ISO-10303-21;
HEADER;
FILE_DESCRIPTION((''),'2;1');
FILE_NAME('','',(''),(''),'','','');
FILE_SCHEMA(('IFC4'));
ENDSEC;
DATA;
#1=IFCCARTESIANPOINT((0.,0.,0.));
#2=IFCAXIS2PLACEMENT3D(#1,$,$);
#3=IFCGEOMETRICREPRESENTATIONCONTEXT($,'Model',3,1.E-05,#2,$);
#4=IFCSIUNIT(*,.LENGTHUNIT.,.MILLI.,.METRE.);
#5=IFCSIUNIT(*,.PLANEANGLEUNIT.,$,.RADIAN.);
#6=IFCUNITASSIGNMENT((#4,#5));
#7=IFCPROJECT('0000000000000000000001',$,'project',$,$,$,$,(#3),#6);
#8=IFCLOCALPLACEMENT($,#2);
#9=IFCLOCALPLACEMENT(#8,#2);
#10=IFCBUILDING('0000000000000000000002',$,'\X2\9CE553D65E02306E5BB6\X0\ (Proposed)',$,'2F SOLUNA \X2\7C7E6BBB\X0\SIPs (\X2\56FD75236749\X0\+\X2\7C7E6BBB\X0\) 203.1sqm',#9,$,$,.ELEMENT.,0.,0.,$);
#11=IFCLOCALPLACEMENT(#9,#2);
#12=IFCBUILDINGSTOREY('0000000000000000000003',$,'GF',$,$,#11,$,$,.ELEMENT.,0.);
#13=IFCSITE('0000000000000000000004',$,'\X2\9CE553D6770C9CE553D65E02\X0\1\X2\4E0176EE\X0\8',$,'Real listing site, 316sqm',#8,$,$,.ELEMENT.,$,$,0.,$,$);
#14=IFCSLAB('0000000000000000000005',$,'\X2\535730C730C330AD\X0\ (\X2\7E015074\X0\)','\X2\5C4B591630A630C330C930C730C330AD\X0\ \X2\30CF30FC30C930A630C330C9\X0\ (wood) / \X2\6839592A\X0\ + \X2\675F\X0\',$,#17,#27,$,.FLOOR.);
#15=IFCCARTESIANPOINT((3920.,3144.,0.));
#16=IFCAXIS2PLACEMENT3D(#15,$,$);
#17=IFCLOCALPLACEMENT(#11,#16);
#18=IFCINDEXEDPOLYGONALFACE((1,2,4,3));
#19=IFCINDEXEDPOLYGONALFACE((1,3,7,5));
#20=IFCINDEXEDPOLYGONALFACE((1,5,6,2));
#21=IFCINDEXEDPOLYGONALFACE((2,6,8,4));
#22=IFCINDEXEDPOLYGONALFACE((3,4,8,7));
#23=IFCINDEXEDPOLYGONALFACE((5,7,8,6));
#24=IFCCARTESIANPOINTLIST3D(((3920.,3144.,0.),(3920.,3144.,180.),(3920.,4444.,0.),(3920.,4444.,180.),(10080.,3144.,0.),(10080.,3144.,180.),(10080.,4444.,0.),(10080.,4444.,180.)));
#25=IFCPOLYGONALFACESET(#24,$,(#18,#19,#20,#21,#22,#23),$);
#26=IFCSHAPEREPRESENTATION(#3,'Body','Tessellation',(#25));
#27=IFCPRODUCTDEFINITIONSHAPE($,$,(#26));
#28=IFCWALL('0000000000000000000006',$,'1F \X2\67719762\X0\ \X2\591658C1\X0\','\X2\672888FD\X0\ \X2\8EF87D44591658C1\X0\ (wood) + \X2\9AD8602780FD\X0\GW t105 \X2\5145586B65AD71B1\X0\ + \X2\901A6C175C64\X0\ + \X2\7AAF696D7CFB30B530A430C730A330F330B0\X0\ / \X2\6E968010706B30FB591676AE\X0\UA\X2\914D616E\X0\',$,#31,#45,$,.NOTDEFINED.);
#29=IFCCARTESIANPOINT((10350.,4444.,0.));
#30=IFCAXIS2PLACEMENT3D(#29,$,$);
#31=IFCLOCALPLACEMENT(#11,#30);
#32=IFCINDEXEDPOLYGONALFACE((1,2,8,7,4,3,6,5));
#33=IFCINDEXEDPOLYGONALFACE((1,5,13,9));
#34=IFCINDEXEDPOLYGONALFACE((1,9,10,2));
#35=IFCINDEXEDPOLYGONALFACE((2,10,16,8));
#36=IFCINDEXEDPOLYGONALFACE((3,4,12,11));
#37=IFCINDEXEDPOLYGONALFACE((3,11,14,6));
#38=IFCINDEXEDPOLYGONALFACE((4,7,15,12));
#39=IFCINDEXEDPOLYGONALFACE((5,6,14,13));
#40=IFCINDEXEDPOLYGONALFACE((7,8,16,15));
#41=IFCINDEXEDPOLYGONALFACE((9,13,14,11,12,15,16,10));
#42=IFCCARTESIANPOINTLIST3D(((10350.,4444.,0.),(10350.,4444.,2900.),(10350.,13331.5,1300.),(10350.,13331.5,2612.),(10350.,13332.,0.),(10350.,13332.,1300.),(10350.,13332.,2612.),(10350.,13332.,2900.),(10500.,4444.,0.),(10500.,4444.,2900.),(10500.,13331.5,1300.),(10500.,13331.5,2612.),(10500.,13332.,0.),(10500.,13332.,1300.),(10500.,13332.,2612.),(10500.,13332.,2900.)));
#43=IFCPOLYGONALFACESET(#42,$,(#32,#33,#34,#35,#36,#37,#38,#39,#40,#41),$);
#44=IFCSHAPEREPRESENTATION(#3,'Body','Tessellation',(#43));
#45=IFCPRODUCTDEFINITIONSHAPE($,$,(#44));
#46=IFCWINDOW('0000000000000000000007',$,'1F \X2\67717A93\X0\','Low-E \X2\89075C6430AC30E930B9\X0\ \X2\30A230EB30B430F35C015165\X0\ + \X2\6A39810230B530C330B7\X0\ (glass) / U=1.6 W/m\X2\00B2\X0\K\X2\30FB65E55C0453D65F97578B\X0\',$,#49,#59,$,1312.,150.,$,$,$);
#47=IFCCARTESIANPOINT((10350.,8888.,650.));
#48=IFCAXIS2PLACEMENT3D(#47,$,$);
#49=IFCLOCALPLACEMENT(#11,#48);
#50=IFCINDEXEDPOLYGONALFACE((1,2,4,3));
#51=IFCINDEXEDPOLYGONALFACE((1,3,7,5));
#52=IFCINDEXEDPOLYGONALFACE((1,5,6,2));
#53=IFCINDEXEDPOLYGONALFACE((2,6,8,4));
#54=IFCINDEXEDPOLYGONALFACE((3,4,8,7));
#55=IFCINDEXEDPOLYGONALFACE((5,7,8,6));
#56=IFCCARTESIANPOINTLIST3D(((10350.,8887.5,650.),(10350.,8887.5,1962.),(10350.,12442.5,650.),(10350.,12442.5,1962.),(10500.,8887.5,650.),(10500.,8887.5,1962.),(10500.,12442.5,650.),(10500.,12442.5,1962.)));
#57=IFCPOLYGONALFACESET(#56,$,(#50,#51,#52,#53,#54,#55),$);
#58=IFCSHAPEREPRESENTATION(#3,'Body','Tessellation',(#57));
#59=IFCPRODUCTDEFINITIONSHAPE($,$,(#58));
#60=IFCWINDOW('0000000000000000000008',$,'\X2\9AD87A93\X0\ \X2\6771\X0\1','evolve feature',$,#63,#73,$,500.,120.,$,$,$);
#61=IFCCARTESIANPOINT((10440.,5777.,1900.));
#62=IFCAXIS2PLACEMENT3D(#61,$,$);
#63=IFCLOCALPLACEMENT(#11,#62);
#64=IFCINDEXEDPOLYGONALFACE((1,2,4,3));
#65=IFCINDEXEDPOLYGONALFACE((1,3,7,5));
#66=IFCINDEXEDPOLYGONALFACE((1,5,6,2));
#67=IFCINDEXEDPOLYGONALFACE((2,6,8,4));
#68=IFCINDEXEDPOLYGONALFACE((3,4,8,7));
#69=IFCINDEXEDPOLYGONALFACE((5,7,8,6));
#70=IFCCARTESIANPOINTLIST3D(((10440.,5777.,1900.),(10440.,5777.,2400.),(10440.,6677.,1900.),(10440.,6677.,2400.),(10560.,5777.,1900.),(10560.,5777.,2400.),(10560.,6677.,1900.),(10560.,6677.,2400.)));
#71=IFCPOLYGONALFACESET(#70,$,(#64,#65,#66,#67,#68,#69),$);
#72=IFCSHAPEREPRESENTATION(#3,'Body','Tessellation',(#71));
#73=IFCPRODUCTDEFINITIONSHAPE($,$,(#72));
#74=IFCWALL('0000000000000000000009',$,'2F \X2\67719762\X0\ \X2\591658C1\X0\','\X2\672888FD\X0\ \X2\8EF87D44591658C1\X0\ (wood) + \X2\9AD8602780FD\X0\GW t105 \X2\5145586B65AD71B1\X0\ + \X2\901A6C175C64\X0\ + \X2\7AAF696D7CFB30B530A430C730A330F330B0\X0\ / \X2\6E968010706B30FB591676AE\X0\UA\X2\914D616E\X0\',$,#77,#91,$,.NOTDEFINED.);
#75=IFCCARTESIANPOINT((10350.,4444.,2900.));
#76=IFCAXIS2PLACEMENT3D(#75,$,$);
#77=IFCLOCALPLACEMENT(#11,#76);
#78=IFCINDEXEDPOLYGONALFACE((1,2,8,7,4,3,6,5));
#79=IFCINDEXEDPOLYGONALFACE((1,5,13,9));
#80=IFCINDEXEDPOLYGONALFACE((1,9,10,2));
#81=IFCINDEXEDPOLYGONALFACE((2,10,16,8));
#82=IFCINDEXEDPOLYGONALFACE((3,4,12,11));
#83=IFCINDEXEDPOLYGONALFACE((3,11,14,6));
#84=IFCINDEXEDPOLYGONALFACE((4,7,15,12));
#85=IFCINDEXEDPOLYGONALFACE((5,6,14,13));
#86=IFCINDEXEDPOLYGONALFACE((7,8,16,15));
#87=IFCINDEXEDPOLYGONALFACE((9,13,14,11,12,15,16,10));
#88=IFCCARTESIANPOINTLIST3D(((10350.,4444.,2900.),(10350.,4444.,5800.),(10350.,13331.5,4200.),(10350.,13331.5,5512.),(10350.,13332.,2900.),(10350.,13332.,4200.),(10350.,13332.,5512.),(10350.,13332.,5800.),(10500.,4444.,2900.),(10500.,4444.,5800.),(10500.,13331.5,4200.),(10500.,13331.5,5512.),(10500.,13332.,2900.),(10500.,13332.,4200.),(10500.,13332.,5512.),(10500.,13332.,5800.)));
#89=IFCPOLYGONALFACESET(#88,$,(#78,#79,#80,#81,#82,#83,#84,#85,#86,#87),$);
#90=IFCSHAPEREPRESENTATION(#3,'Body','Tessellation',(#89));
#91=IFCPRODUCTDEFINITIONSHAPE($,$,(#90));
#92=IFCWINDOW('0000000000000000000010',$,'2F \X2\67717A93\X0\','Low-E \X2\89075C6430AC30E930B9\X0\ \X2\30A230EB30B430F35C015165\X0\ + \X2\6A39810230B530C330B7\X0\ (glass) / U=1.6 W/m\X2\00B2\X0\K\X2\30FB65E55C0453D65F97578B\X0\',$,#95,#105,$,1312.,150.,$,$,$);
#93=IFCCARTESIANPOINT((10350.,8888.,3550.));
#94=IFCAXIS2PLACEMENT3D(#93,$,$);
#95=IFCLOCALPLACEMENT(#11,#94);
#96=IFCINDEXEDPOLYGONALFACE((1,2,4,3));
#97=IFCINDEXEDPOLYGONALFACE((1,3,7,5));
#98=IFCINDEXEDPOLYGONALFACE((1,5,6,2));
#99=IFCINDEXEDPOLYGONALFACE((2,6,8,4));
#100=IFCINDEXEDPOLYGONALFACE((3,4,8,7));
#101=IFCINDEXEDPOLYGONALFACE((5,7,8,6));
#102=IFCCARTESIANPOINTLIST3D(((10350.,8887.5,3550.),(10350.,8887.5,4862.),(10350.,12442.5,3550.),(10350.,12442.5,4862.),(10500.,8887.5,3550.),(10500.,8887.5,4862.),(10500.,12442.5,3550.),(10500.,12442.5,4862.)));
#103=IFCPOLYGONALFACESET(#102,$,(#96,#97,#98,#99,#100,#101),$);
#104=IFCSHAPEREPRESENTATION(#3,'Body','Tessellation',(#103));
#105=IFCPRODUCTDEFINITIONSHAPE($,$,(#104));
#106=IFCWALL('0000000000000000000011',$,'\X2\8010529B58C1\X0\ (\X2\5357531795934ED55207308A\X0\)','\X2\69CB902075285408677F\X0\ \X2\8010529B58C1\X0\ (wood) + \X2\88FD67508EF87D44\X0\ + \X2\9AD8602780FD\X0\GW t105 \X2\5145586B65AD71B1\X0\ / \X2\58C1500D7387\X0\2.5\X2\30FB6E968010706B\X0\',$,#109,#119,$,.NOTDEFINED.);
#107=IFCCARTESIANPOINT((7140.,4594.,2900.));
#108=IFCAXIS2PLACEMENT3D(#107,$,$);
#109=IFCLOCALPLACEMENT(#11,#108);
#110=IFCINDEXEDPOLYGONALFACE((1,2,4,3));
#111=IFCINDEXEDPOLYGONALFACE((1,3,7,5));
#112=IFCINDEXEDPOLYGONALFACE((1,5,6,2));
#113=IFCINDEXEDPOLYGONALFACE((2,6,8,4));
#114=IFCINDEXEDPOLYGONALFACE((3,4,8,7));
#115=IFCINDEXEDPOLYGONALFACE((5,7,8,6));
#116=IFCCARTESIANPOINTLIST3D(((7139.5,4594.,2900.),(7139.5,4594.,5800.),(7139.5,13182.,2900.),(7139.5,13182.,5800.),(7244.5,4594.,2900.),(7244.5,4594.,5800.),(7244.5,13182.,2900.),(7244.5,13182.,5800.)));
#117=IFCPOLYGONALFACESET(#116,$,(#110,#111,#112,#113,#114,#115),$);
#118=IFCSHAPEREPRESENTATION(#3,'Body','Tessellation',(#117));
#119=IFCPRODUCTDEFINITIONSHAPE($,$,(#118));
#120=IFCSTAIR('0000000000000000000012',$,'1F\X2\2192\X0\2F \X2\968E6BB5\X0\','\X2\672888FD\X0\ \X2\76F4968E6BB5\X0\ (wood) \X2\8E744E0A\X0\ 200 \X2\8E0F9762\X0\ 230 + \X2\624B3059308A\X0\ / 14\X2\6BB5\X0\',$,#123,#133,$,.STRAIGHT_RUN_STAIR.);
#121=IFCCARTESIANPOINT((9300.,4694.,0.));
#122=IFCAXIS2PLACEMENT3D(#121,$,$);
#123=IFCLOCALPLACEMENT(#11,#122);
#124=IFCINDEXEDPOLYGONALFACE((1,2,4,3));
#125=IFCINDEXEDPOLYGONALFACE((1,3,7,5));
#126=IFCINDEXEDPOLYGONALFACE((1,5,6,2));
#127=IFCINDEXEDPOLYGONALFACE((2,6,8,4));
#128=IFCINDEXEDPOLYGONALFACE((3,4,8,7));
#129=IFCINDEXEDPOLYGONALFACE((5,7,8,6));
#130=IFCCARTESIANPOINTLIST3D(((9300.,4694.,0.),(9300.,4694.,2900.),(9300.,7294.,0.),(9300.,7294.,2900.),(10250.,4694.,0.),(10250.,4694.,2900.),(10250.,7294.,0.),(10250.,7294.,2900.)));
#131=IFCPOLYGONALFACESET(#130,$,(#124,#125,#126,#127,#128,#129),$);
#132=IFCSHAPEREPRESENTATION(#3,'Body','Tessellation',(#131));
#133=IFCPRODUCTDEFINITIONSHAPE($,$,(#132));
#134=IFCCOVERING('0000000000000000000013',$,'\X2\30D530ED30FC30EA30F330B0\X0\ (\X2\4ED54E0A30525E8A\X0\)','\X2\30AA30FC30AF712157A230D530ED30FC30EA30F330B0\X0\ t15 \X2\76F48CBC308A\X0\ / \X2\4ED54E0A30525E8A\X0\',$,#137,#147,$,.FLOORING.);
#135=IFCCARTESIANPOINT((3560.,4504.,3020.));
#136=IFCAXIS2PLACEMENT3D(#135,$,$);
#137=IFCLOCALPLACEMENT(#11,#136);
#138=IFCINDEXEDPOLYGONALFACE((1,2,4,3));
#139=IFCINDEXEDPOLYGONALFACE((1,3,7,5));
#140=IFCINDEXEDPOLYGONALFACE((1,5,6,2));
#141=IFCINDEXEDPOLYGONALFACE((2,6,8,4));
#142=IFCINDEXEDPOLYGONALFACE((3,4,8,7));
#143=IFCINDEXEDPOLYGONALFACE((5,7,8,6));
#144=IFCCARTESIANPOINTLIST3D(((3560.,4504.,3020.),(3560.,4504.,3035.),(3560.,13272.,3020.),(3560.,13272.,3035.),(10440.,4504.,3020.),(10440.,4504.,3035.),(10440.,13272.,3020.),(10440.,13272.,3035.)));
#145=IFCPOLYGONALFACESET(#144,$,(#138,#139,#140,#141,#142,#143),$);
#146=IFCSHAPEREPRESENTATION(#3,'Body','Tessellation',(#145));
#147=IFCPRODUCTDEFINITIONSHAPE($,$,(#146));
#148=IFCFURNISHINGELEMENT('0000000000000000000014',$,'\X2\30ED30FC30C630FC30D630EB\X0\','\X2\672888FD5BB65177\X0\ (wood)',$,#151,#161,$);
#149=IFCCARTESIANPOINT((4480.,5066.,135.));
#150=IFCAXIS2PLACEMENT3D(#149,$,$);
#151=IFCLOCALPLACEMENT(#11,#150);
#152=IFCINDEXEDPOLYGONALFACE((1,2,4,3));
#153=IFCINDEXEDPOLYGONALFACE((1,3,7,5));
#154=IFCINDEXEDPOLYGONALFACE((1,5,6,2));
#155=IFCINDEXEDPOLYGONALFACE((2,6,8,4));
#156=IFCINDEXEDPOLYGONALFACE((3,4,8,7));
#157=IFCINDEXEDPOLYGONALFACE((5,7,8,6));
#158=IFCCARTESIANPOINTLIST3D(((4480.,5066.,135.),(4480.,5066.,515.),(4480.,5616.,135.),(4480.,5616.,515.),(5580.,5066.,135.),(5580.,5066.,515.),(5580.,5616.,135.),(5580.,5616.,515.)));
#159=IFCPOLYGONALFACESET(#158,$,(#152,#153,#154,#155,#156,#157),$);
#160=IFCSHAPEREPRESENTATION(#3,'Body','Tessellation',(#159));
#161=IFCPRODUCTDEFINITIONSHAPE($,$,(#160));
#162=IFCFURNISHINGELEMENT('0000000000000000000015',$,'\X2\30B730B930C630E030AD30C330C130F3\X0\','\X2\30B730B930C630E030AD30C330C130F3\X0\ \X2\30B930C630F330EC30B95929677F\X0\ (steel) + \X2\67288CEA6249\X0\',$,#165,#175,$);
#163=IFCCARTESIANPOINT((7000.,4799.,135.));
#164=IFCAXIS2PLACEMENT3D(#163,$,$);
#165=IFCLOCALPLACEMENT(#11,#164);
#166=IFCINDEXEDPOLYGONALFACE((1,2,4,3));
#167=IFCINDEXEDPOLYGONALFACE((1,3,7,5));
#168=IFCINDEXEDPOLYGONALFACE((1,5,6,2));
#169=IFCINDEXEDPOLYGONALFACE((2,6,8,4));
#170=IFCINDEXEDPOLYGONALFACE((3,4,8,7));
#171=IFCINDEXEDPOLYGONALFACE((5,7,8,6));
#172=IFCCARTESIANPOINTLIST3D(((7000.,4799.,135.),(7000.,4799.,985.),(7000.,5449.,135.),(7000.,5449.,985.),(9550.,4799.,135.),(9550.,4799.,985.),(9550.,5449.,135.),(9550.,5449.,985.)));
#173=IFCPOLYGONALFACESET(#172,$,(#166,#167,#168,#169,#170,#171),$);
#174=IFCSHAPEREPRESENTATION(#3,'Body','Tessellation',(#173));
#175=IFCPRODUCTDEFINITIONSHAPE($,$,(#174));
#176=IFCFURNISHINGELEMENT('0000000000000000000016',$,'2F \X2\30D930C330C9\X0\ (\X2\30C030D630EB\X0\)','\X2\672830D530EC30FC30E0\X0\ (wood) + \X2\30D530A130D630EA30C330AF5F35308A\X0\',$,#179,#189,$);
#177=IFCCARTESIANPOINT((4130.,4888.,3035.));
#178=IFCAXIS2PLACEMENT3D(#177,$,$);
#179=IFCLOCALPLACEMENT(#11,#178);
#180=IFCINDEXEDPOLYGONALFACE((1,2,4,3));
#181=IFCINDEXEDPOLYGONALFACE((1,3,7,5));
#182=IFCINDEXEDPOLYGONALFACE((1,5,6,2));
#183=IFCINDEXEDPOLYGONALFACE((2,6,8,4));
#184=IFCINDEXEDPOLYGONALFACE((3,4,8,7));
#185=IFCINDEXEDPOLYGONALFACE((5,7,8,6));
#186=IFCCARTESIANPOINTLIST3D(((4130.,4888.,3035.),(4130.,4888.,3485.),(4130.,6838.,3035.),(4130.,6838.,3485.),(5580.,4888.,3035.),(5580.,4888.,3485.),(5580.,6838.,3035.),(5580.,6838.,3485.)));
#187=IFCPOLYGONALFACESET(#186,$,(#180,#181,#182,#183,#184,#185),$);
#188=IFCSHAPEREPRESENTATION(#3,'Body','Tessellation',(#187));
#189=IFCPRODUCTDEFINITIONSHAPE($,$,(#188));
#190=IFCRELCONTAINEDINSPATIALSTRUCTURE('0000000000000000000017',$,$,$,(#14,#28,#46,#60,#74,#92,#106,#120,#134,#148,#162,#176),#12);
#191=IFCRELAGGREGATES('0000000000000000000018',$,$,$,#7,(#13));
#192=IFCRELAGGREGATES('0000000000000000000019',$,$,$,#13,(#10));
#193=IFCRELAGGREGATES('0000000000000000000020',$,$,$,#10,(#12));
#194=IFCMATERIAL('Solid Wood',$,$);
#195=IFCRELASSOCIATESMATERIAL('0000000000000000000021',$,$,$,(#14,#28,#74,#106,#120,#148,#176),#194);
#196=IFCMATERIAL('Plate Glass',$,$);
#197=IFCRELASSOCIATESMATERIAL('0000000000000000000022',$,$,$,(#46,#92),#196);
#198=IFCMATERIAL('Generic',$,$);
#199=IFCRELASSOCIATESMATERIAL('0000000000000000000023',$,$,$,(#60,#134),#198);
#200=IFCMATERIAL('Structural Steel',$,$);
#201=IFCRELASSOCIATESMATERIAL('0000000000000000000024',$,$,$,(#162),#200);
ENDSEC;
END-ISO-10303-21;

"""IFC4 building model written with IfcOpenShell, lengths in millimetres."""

from ifc_helpers import new_model, si_unit, frame, frame_2d, origin, place, context, project, spatial, rectangle, extrude, material, element, fill, save


model = new_model("IFC4")

# Units and contexts
model_context = context("Model", 3, precision=1e-05, world=origin())
ifc_project = project(units=[si_unit("LENGTHUNIT", "METRE", prefix="MILLI"), si_unit("PLANEANGLEUNIT", "RADIAN")], contexts=[model_context])

# Site, building, storey
site_placement = place(None, origin())
site = spatial("IfcSite", under=ifc_project, at=site_placement, Name="鳥取県鳥取市1丁目8", ObjectType="Real listing site, 316sqm", CompositionType="ELEMENT", RefElevation=0.0)
building_placement = place(site_placement, origin())
building = spatial("IfcBuilding", under=site, at=building_placement, Name="鳥取市の家 (Proposed)", ObjectType="2F SOLUNA 籾殻SIPs (国産杉+籾殻) 203.1sqm", CompositionType="ELEMENT", ElevationOfRefHeight=0.0, ElevationOfTerrain=0.0)
storey_placement = place(building_placement, origin())
storey = spatial("IfcBuildingStorey", under=building, at=storey_placement, Name="GF", CompositionType="ELEMENT", Elevation=0.0)

# Slab
ifc_material_1 = material(Name="Solid Wood")
slab_placement = place(storey_placement, frame((3920.0, 3144.0, 0.0)))
element("IfcSlab", 1, at=slab_placement, inside=storey, material=ifc_material_1, Name="南デッキ (縁側)", Description="屋外ウッドデッキ ハードウッド (wood) / 根太 + 束", PredefinedType="FLOOR", context=model_context, shape_type="SweptSolid", body=[
    extrude(rectangle(XDim=6160.0, YDim=1300.0, at=frame_2d((3080.0, 650.0))), frame((3920.0, 3144.0, 0.0)), (0.0, 0.0, 1.0), 180.0),
])

# Wall, openings, windows
wall_1_placement = place(storey_placement, frame((10350.0, 4444.0, 0.0)))
wall_1 = element("IfcWall", 2, at=wall_1_placement, inside=storey, material=ifc_material_1, Name="1F 東面 外壁", Description="木製 軸組外壁 (wood) + 高性能GW t105 充填断熱 + 通気層 + 窯業系サイディング / 準耐火・外皮UA配慮", PredefinedType="NOTDEFINED", context=model_context, shape_type="SweptSolid", body=[
    extrude(rectangle(XDim=150.0, YDim=8888.0, at=frame_2d((75.0, 4444.0))), frame((10350.0, 4444.0, 0.0)), (0.0, 0.0, 1.0), 2900.0),
])
opening_1_placement = place(storey_placement, frame((10350.0, 8888.0, 650.0)))
opening_1 = element("IfcOpeningElement", 3, at=opening_1_placement, cuts=wall_1, PredefinedType="NOTDEFINED", context=model_context, shape_type="SweptSolid", body=[
    extrude(rectangle(XDim=150.0, YDim=3555.0, at=frame_2d((75.0, 1777.0))), frame((10350.0, 8888.0, 650.0)), (0.0, 0.0, 1.0), 1312.0),
])
opening_2_placement = place(storey_placement, frame((10440.0, 5777.0, 1900.0)))
opening_2 = element("IfcOpeningElement", 4, at=opening_2_placement, cuts=wall_1, PredefinedType="NOTDEFINED", context=model_context, shape_type="SweptSolid", body=[
    extrude(rectangle(XDim=120.0, YDim=900.0, at=frame_2d((60.0, 450.0))), frame((10440.0, 5777.0, 1900.0)), (0.0, 0.0, 1.0), 500.0),
])
ifc_material_2 = material(Name="Plate Glass")
window_1_placement = place(storey_placement, frame((10350.0, 8888.0, 650.0)))
window_1 = element("IfcWindow", 5, at=window_1_placement, inside=storey, material=ifc_material_2, Name="1F 東窓", Description="Low-E 複層ガラス アルゴン封入 + 樹脂サッシ (glass) / U=1.6 W/m²K・日射取得型", OverallHeight=1312.0, OverallWidth=150.0, context=model_context, shape_type="SweptSolid", body=[
    extrude(rectangle(XDim=150.0, YDim=3555.0, at=frame_2d((75.0, 1777.0))), frame((10350.0, 8888.0, 650.0)), (0.0, 0.0, 1.0), 1312.0),
])
fill(opening_1, window_1)
ifc_material_3 = material(Name="Generic")
window_2_placement = place(storey_placement, frame((10440.0, 5777.0, 1900.0)))
window_2 = element("IfcWindow", 6, at=window_2_placement, inside=storey, material=ifc_material_3, Name="高窓 東1", Description="evolve feature", OverallHeight=500.0, OverallWidth=120.0, context=model_context, shape_type="SweptSolid", body=[
    extrude(rectangle(XDim=120.0, YDim=900.0, at=frame_2d((60.0, 450.0))), frame((10440.0, 5777.0, 1900.0)), (0.0, 0.0, 1.0), 500.0),
])
fill(opening_2, window_2)

# Wall, opening, window
wall_2_placement = place(storey_placement, frame((10350.0, 4444.0, 2900.0)))
wall_2 = element("IfcWall", 7, at=wall_2_placement, inside=storey, material=ifc_material_1, Name="2F 東面 外壁", Description="木製 軸組外壁 (wood) + 高性能GW t105 充填断熱 + 通気層 + 窯業系サイディング / 準耐火・外皮UA配慮", PredefinedType="NOTDEFINED", context=model_context, shape_type="SweptSolid", body=[
    extrude(rectangle(XDim=150.0, YDim=8888.0, at=frame_2d((75.0, 4444.0))), frame((10350.0, 4444.0, 2900.0)), (0.0, 0.0, 1.0), 2900.0),
])
opening_3_placement = place(storey_placement, frame((10350.0, 8888.0, 3550.0)))
opening_3 = element("IfcOpeningElement", 8, at=opening_3_placement, cuts=wall_2, PredefinedType="NOTDEFINED", context=model_context, shape_type="SweptSolid", body=[
    extrude(rectangle(XDim=150.0, YDim=3555.0, at=frame_2d((75.0, 1777.0))), frame((10350.0, 8888.0, 3550.0)), (0.0, 0.0, 1.0), 1312.0),
])
window_3_placement = place(storey_placement, frame((10350.0, 8888.0, 3550.0)))
window_3 = element("IfcWindow", 9, at=window_3_placement, inside=storey, material=ifc_material_2, Name="2F 東窓", Description="Low-E 複層ガラス アルゴン封入 + 樹脂サッシ (glass) / U=1.6 W/m²K・日射取得型", OverallHeight=1312.0, OverallWidth=150.0, context=model_context, shape_type="SweptSolid", body=[
    extrude(rectangle(XDim=150.0, YDim=3555.0, at=frame_2d((75.0, 1777.0))), frame((10350.0, 8888.0, 3550.0)), (0.0, 0.0, 1.0), 1312.0),
])
fill(opening_3, window_3)

# Wall
wall_3_placement = place(storey_placement, frame((7140.0, 4594.0, 2900.0)))
element("IfcWall", 10, at=wall_3_placement, inside=storey, material=ifc_material_1, Name="耐力壁 (南北間仕切り)", Description="構造用合板 耐力壁 (wood) + 製材軸組 + 高性能GW t105 充填断熱 / 壁倍率2.5・準耐火", PredefinedType="NOTDEFINED", context=model_context, shape_type="SweptSolid", body=[
    extrude(rectangle(XDim=105.0, YDim=8588.0, at=frame_2d((52.0, 4294.0))), frame((7140.0, 4594.0, 2900.0)), (0.0, 0.0, 1.0), 2900.0),
])

# Stair
stair_placement = place(storey_placement, frame((9300.0, 4694.0, 0.0)))
element("IfcStair", 11, at=stair_placement, inside=storey, material=ifc_material_1, Name="1F→2F 階段", Description="木製 直階段 (wood) 蹴上 200 踏面 230 + 手すり / 14段", PredefinedType="STRAIGHT_RUN_STAIR", context=model_context, shape_type="SweptSolid", body=[
    extrude(rectangle(XDim=950.0, YDim=2600.0, at=frame_2d((475.0, 1300.0))), frame((9300.0, 4694.0, 0.0)), (0.0, 0.0, 1.0), 2900.0),
])

# Covering
covering_placement = place(storey_placement, frame((3560.0, 4504.0, 3020.0)))
element("IfcCovering", 12, at=covering_placement, inside=storey, material=ifc_material_3, Name="フローリング (仕上げ床)", Description="オーク無垢フローリング t15 直貼り / 仕上げ床", PredefinedType="FLOORING", context=model_context, shape_type="SweptSolid", body=[
    extrude(rectangle(XDim=6880.0, YDim=8768.0, at=frame_2d((3440.0, 4384.0))), frame((3560.0, 4504.0, 3020.0)), (0.0, 0.0, 1.0), 15.0),
])

# Furnishing elements
furnishing_1_placement = place(storey_placement, frame((4480.0, 5066.0, 135.0)))
element("IfcFurnishingElement", 13, at=furnishing_1_placement, inside=storey, material=ifc_material_1, Name="ローテーブル", Description="木製家具 (wood)", context=model_context, shape_type="SweptSolid", body=[
    extrude(rectangle(XDim=1100.0, YDim=550.0, at=frame_2d((550.0, 275.0))), frame((4480.0, 5066.0, 135.0)), (0.0, 0.0, 1.0), 380.0),
])
ifc_material_4 = material(Name="Structural Steel")
furnishing_2_placement = place(storey_placement, frame((7000.0, 4799.0, 135.0)))
element("IfcFurnishingElement", 14, at=furnishing_2_placement, inside=storey, material=ifc_material_4, Name="システムキッチン", Description="システムキッチン ステンレス天板 (steel) + 木質扉", context=model_context, shape_type="SweptSolid", body=[
    extrude(rectangle(XDim=2550.0, YDim=650.0, at=frame_2d((1275.0, 325.0))), frame((7000.0, 4799.0, 135.0)), (0.0, 0.0, 1.0), 850.0),
])
furnishing_3_placement = place(storey_placement, frame((4130.0, 4888.0, 3035.0)))
element("IfcFurnishingElement", 15, at=furnishing_3_placement, inside=storey, material=ifc_material_1, Name="2F ベッド (ダブル)", Description="木フレーム (wood) + ファブリック張り", context=model_context, shape_type="SweptSolid", body=[
    extrude(rectangle(XDim=1450.0, YDim=1950.0, at=frame_2d((725.0, 975.0))), frame((4130.0, 4888.0, 3035.0)), (0.0, 0.0, 1.0), 450.0),
])

save(model, "model.ifc")
